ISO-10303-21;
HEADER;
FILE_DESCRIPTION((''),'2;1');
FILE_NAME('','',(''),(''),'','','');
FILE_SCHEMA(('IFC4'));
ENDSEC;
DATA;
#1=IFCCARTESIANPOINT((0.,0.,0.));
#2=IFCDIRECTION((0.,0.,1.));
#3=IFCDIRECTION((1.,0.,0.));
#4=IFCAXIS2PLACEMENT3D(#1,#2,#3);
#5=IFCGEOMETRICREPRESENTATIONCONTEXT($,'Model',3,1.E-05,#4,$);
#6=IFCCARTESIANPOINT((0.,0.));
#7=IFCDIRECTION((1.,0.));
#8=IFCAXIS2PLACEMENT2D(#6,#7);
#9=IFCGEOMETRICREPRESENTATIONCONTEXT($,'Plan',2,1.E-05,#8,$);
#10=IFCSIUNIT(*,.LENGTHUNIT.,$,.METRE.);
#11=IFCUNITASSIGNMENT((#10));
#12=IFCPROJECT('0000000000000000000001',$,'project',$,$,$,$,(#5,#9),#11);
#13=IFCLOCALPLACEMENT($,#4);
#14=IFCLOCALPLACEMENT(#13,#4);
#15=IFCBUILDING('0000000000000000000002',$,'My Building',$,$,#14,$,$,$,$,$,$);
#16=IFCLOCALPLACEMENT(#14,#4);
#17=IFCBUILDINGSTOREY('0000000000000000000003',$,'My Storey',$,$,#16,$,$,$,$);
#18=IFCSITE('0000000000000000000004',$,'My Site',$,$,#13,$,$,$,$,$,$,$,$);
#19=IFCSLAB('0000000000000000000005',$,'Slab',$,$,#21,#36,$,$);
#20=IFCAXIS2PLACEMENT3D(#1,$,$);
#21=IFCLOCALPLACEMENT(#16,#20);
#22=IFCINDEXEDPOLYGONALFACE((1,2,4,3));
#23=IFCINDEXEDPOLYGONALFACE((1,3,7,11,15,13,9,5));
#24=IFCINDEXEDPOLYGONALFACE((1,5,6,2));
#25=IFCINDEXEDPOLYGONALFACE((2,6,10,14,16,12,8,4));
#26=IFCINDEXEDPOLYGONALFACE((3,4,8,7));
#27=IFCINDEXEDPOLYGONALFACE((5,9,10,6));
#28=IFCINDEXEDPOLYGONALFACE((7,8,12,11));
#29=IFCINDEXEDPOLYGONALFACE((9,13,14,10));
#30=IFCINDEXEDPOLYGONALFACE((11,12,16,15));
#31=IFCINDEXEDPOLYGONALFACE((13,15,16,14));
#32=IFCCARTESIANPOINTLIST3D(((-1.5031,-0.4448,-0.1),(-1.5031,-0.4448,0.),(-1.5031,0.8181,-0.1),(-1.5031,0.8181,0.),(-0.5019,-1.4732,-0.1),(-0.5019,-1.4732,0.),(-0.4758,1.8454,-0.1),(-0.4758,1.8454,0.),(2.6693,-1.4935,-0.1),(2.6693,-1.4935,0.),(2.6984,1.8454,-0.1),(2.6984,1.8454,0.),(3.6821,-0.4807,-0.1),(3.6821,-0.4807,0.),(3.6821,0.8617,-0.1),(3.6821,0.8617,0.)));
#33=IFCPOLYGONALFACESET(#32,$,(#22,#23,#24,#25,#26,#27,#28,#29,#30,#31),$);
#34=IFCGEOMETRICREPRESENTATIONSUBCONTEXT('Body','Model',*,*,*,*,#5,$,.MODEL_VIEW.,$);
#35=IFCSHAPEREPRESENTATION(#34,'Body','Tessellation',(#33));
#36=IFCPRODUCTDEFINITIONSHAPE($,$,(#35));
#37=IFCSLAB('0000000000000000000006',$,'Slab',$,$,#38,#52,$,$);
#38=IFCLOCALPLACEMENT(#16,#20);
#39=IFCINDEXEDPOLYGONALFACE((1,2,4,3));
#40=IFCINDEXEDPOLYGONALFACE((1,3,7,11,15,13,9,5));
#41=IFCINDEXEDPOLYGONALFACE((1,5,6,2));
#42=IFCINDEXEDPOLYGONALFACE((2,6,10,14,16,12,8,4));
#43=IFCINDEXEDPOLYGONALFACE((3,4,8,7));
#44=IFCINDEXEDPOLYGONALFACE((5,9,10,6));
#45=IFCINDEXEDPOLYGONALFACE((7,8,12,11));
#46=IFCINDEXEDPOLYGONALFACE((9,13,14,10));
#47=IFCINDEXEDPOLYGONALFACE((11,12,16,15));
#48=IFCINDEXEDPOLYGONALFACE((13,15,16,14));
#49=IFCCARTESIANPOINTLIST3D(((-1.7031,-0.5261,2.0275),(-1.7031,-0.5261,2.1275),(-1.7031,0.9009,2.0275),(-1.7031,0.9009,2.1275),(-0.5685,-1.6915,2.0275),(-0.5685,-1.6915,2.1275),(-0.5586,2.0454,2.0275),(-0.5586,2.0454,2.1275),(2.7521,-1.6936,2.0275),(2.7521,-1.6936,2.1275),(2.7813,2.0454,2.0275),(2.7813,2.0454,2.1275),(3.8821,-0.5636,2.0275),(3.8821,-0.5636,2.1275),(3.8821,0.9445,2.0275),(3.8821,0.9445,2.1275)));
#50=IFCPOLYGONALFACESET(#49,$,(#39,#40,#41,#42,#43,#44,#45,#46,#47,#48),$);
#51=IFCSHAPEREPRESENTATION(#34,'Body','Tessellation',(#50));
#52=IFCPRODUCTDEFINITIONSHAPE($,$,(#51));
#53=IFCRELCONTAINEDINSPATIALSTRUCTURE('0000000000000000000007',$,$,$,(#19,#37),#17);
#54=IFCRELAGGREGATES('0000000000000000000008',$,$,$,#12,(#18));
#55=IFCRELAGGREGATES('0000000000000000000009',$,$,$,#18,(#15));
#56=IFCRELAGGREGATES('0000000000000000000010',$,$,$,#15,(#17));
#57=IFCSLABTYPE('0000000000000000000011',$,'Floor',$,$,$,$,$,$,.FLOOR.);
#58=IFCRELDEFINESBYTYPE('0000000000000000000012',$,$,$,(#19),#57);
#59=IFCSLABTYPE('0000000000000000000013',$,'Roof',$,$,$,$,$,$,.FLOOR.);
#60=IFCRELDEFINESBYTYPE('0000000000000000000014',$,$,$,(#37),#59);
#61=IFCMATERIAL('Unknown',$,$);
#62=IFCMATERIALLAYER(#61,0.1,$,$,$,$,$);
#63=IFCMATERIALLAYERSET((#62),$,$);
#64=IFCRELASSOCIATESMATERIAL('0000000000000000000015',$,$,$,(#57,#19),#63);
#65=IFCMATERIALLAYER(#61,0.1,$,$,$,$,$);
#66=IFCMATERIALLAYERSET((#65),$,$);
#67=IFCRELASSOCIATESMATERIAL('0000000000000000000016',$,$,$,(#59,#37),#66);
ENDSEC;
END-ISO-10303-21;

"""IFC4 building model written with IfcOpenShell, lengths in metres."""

from ifc_helpers import new_model, si_unit, frame, origin_with_axes, origin_2d_with_axis, place, context, subcontext, project, spatial, indexed_curve, outline, extrude, material, layer, layer_set, layer_usage, type_object, element, save


model = new_model("IFC4")

# Units and contexts
model_context = context("Model", 3, precision=1e-05, world=origin_with_axes())
plan_context = context("Plan", 2, precision=1e-05, world=origin_2d_with_axis())
body_context_1 = subcontext(model_context, "Body", "Model", "MODEL_VIEW")
ifc_project = project(units=[si_unit("LENGTHUNIT", "METRE")], contexts=[model_context, plan_context])

# Site, building, storey
site_placement = place(None, origin_with_axes())
site = spatial("IfcSite", under=ifc_project, at=site_placement, Name="My Site")
building_placement = place(site_placement, origin_with_axes())
building = spatial("IfcBuilding", under=site, at=building_placement, Name="My Building")
storey_placement = place(building_placement, origin_with_axes())
storey = spatial("IfcBuildingStorey", under=building, at=storey_placement, Name="My Storey")

# Slabs
ifc_material = material(Name="Unknown")
ifc_layer_1 = layer(ifc_material, 0.1)
ifc_layer_set_1 = layer_set([ifc_layer_1])
ifc_layer_usage_1 = layer_usage(ifc_layer_set_1, "AXIS3", "POSITIVE", -0.1)
slab_type_1 = type_object("IfcSlabType", Name="Floor", PredefinedType="FLOOR", material=ifc_layer_set_1)
slab_1_placement = place(storey_placement, frame((-0.4758, 1.8454, 0.0), z_axis=(0.0, 0.0, 1.0), x_axis=(1.0, 0.0, 0.0)))
element("IfcSlab", 1, at=slab_1_placement, inside=storey, type_object=slab_type_1, material=ifc_layer_usage_1, Name="Slab", context=body_context_1, shape_type="SweptSolid", body=[
    extrude(outline(indexed_curve([(0.0, 0.0), (3.1742, 0.0), (4.1579, -0.9837), (4.1579, -2.3261), (3.1451, -3.3389), (-0.0262, -3.3186), (-1.0273, -2.2902), (-1.0273, -1.0273), (0.0, 0.0)])), frame((0.0, 0.0, -0.1), z_axis=(0.0, 0.0, 1.0), x_axis=(1.0, 0.0, 0.0)), (0.0, 0.0, 1.0), 0.1),
])
ifc_layer_2 = layer(ifc_material, 0.1)
ifc_layer_set_2 = layer_set([ifc_layer_2])
ifc_layer_usage_2 = layer_usage(ifc_layer_set_2, "AXIS3", "POSITIVE", -0.1)
slab_type_2 = type_object("IfcSlabType", Name="Roof", PredefinedType="FLOOR", material=ifc_layer_set_2)
slab_2_placement = place(storey_placement, frame((-1.7031, 0.9009, 2.1275), z_axis=(0.0, 0.0, 1.0), x_axis=(1.0, 0.0, 0.0)))
element("IfcSlab", 2, at=slab_2_placement, inside=storey, type_object=slab_type_2, material=ifc_layer_usage_2, Name="Slab", context=body_context_1, shape_type="SweptSolid", body=[
    extrude(outline(indexed_curve([(1.1445, 1.1445), (4.4844, 1.1445), (5.5852, 0.0436), (5.5852, -1.4645), (4.4552, -2.5945), (1.1346, -2.5924), (0.0, -1.427), (0.0, 0.0), (1.1445, 1.1445)])), frame((0.0, 0.0, -0.1), z_axis=(0.0, 0.0, 1.0), x_axis=(1.0, 0.0, 0.0)), (0.0, 0.0, 1.0), 0.1),
])

save(model, "model.ifc")
